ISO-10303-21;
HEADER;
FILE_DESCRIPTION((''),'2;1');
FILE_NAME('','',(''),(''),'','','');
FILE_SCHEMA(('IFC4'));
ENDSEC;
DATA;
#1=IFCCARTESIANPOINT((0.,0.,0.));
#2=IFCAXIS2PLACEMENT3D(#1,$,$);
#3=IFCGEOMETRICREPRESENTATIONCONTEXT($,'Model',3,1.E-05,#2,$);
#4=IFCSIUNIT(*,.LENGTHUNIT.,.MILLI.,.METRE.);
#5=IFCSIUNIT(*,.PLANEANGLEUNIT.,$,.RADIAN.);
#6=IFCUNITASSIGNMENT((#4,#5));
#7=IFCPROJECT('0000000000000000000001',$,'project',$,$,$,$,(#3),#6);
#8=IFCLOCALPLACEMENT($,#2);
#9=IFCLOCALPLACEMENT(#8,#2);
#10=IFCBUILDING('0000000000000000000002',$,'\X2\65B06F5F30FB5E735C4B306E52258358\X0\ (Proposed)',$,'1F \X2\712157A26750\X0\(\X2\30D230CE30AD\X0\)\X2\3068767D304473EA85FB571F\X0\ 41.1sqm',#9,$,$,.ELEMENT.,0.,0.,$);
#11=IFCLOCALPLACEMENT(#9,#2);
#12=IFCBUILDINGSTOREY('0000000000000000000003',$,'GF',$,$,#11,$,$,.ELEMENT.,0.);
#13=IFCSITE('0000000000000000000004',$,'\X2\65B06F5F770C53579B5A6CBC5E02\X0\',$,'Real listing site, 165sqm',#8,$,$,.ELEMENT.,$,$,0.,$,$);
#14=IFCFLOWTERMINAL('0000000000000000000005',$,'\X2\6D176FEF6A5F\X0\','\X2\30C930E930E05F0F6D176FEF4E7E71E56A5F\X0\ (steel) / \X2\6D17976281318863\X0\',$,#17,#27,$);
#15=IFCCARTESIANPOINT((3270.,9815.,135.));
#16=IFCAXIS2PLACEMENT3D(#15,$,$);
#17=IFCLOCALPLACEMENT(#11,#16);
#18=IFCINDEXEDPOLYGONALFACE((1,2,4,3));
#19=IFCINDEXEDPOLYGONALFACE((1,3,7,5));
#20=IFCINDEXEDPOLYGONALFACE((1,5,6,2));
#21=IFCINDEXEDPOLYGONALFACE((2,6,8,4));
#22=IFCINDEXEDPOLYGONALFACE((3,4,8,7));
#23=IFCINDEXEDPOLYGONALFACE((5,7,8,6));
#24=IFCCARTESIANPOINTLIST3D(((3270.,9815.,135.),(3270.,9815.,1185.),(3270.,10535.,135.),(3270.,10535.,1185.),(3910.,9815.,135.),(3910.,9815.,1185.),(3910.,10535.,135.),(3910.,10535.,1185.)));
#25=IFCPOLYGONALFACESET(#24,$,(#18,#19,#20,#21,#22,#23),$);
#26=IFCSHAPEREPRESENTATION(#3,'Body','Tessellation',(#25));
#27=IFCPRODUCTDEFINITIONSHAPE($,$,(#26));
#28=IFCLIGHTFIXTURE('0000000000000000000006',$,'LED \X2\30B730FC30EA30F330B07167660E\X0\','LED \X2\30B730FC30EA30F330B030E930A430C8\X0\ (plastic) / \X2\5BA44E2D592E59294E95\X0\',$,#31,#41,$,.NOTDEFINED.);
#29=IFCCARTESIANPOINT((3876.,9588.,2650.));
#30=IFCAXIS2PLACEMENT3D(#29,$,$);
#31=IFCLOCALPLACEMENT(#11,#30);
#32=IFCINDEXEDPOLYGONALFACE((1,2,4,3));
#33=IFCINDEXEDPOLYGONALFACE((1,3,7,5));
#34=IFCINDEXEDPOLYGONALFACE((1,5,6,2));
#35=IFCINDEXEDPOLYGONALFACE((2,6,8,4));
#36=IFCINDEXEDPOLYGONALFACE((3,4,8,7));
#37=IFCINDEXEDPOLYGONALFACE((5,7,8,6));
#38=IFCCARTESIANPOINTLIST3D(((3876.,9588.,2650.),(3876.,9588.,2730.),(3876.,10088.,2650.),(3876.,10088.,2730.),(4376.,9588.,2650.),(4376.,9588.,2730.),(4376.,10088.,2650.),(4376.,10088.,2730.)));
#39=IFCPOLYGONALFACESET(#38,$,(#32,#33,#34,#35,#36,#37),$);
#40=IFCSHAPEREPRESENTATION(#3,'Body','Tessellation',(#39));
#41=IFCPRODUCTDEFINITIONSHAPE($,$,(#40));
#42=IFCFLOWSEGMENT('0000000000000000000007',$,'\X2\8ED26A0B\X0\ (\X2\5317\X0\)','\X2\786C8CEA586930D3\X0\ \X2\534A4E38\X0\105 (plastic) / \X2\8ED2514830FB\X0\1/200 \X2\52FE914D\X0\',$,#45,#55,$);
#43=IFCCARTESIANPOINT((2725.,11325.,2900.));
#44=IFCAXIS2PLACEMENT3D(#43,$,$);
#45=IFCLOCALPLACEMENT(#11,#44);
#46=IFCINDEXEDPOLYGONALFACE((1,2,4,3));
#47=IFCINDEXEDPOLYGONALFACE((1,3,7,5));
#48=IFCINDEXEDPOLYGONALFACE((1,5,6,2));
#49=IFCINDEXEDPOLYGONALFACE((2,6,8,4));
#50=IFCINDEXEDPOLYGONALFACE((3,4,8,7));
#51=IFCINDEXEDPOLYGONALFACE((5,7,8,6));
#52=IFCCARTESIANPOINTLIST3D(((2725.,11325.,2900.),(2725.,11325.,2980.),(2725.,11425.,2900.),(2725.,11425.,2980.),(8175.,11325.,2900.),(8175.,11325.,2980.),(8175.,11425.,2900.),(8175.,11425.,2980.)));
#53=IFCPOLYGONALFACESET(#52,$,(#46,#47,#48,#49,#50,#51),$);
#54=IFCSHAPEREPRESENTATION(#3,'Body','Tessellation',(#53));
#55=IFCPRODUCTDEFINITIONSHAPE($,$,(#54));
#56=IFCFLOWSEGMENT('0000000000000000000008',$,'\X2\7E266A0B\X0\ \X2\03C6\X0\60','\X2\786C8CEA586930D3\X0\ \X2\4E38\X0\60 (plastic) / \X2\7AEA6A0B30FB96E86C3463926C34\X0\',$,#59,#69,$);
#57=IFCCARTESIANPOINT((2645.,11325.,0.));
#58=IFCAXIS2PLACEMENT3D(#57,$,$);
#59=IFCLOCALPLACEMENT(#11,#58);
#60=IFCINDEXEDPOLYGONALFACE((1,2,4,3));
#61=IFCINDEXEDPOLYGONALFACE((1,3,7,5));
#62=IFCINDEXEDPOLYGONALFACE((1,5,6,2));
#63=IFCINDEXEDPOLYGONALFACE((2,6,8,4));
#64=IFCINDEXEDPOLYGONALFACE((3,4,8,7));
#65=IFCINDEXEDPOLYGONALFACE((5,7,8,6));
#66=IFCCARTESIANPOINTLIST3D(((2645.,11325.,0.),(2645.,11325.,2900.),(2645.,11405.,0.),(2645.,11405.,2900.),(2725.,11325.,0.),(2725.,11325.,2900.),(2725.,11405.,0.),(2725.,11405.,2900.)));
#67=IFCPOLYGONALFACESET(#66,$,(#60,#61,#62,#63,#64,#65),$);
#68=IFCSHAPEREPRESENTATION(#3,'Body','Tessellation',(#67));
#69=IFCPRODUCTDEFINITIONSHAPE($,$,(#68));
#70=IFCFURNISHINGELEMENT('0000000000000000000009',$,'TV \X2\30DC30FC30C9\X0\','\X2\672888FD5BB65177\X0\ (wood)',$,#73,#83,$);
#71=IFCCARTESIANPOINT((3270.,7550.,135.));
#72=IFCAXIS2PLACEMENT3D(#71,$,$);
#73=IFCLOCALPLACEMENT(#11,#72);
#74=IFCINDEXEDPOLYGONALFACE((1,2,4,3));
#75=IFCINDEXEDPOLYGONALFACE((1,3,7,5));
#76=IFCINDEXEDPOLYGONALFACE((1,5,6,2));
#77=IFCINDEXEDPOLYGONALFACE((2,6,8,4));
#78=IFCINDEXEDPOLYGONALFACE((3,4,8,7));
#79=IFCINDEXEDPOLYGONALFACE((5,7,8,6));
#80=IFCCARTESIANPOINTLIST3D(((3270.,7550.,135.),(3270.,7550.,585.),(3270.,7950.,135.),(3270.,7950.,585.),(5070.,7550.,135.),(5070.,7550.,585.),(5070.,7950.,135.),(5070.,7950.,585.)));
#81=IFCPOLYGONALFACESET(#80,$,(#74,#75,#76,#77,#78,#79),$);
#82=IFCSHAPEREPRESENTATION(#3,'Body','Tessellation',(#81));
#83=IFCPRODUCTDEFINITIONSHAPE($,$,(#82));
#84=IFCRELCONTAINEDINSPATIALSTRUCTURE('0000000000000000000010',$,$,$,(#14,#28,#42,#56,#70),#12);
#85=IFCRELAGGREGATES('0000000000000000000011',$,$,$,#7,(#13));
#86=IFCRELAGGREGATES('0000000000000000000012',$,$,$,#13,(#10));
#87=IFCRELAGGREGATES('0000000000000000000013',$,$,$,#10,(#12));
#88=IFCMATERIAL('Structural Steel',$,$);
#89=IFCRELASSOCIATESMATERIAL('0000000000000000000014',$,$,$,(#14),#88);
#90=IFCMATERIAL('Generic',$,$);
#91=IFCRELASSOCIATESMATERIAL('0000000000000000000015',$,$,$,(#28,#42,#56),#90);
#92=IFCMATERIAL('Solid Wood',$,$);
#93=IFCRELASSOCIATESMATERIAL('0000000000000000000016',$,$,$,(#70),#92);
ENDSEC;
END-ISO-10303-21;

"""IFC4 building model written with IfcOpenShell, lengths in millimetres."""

from ifc_helpers import new_model, si_unit, frame, frame_2d, origin, place, context, project, spatial, rectangle, extrude, material, element, save


model = new_model("IFC4")

# Units and contexts
model_context = context("Model", 3, precision=1e-05, world=origin())
ifc_project = project(units=[si_unit("LENGTHUNIT", "METRE", prefix="MILLI"), si_unit("PLANEANGLEUNIT", "RADIAN")], contexts=[model_context])

# Site, building, storey
site_placement = place(None, origin())
site = spatial("IfcSite", under=ifc_project, at=site_placement, Name="新潟県南魚沼市", ObjectType="Real listing site, 165sqm", CompositionType="ELEMENT", RefElevation=0.0)
building_placement = place(site_placement, origin())
building = spatial("IfcBuilding", under=site, at=building_placement, Name="新潟・平屋の別荘 (Proposed)", ObjectType="1F 無垢材(ヒノキ)と白い珪藻土 41.1sqm", CompositionType="ELEMENT", ElevationOfRefHeight=0.0, ElevationOfTerrain=0.0)
storey_placement = place(building_placement, origin())
storey = spatial("IfcBuildingStorey", under=building, at=storey_placement, Name="GF", CompositionType="ELEMENT", Elevation=0.0)

# Shared definitions
ifc_material_1 = material(Name="Solid Wood")

# Shared definitions
ifc_material_2 = material(Name="Generic")

# Shared definitions
ifc_material_3 = material(Name="Structural Steel")

# Flow terminal
flow_terminal_placement = place(storey_placement, frame((3270.0, 9815.0, 135.0)))
element("IfcFlowTerminal", 1, at=flow_terminal_placement, inside=storey, material=ifc_material_3, Name="洗濯機", Description="ドラム式洗濯乾燥機 (steel) / 洗面脱衣", context=model_context, shape_type="SweptSolid", body=[
    extrude(rectangle(XDim=640.0, YDim=720.0, at=frame_2d((320.0, 360.0))), frame((3270.0, 9815.0, 135.0)), (0.0, 0.0, 1.0), 1050.0),
])

# Light fixture
light_fixture_placement = place(storey_placement, frame((3876.0, 9588.0, 2650.0)))
element("IfcLightFixture", 2, at=light_fixture_placement, inside=storey, material=ifc_material_2, Name="LED シーリング照明", Description="LED シーリングライト (plastic) / 室中央天井", PredefinedType="NOTDEFINED", context=model_context, shape_type="SweptSolid", body=[
    extrude(rectangle(XDim=500.0, YDim=500.0, at=frame_2d((250.0, 250.0))), frame((3876.0, 9588.0, 2650.0)), (0.0, 0.0, 1.0), 80.0),
])

# Flow segments
flow_segment_1_placement = place(storey_placement, frame((2725.0, 11325.0, 2900.0)))
element("IfcFlowSegment", 3, at=flow_segment_1_placement, inside=storey, material=ifc_material_2, Name="軒樋 (北)", Description="硬質塩ビ 半丸105 (plastic) / 軒先・1/200 勾配", context=model_context, shape_type="SweptSolid", body=[
    extrude(rectangle(XDim=5450.0, YDim=100.0, at=frame_2d((2725.0, 50.0))), frame((2725.0, 11325.0, 2900.0)), (0.0, 0.0, 1.0), 80.0),
])
flow_segment_2_placement = place(storey_placement, frame((2645.0, 11325.0, 0.0)))
element("IfcFlowSegment", 4, at=flow_segment_2_placement, inside=storey, material=ifc_material_2, Name="縦樋 φ60", Description="硬質塩ビ 丸60 (plastic) / 竪樋・雨水排水", context=model_context, shape_type="SweptSolid", body=[
    extrude(rectangle(XDim=80.0, YDim=80.0, at=frame_2d((40.0, 40.0))), frame((2645.0, 11325.0, 0.0)), (0.0, 0.0, 1.0), 2900.0),
])

# Furnishing element
furnishing_placement = place(storey_placement, frame((3270.0, 7550.0, 135.0)))
element("IfcFurnishingElement", 5, at=furnishing_placement, inside=storey, material=ifc_material_1, Name="TV ボード", Description="木製家具 (wood)", context=model_context, shape_type="SweptSolid", body=[
    extrude(rectangle(XDim=1800.0, YDim=400.0, at=frame_2d((900.0, 200.0))), frame((3270.0, 7550.0, 135.0)), (0.0, 0.0, 1.0), 450.0),
])

save(model, "model.ifc")
